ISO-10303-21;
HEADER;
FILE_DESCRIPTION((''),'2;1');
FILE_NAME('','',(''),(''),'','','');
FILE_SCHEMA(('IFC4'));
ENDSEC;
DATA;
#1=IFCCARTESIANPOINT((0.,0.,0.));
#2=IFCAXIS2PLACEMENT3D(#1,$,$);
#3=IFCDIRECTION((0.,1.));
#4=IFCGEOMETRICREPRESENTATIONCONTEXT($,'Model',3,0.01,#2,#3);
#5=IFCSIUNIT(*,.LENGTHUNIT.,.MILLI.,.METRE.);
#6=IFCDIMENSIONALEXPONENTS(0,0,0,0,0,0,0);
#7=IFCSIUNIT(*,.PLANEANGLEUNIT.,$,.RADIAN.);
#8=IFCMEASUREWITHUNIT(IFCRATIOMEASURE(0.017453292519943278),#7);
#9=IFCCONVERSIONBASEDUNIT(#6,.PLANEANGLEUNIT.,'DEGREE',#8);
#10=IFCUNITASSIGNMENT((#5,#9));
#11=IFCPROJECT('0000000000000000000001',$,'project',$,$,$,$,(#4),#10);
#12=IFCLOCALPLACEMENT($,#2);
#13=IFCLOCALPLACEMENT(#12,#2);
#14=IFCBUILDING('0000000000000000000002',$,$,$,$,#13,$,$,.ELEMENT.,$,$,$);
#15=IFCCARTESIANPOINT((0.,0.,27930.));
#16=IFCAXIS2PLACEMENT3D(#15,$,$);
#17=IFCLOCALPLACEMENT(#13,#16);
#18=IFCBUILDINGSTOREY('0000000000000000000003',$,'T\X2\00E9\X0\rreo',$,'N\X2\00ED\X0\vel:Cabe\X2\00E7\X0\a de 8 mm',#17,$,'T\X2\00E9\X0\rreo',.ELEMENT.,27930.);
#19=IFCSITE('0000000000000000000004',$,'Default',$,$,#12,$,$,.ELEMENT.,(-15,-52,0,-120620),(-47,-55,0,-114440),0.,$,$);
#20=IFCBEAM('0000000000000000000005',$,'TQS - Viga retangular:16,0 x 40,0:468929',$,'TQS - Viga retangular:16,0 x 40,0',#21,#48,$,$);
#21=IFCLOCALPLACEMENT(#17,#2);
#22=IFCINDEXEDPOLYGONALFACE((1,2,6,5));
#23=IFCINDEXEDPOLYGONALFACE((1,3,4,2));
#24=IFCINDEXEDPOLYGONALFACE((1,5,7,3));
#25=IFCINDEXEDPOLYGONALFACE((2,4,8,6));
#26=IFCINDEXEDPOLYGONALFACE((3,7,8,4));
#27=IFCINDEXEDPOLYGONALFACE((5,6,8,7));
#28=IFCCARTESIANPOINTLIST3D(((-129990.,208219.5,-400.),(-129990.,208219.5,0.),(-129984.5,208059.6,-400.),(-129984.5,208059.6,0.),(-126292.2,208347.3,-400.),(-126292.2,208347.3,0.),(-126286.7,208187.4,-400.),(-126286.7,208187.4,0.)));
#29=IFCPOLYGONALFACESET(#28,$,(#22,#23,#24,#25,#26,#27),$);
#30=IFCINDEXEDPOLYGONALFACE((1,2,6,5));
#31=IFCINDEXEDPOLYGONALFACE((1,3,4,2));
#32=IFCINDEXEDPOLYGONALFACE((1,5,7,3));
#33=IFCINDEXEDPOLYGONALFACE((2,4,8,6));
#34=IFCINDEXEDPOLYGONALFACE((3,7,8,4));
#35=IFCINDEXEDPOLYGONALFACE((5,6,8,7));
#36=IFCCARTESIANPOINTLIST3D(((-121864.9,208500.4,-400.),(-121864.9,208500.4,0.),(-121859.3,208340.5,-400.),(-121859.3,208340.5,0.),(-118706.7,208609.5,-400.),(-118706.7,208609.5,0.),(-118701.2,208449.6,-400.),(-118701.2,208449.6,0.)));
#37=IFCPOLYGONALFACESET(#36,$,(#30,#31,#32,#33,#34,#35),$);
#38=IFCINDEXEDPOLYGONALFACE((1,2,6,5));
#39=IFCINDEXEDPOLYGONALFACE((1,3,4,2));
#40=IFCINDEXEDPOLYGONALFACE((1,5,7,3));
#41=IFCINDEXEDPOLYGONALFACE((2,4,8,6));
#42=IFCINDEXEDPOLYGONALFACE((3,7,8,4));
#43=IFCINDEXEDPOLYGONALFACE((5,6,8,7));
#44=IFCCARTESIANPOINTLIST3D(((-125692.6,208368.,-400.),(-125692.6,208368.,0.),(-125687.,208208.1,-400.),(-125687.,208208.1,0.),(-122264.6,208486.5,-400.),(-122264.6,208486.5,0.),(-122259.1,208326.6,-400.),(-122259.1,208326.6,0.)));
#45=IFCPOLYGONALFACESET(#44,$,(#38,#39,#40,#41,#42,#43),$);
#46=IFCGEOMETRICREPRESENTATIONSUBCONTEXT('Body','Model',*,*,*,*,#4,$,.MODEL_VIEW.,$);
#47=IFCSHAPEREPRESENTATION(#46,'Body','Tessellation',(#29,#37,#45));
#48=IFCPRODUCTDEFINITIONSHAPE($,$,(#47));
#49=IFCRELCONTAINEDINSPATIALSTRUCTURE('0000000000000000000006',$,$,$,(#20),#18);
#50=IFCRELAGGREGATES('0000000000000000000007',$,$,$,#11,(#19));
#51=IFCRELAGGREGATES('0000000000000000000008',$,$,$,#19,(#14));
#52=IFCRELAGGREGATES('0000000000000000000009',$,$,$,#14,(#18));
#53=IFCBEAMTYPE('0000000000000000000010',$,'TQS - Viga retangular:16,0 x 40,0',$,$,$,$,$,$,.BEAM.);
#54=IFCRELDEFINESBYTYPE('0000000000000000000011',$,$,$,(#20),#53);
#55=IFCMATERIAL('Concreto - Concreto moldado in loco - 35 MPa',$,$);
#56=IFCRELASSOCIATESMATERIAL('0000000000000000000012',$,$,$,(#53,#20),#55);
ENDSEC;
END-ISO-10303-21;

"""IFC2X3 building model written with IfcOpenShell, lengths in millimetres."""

from ifc_helpers import new_model, entity, si_unit, converted_unit, direction, frame, frame_2d, origin, place, context, subcontext, project, spatial, rectangle, extrude, source, transform, mapped, material, type_object, type_shapes, element, save


model = new_model("IFC2X3")

# Units and contexts
model_context = context("Model", 3, precision=0.01, world=origin(), true_north=direction((0.0, 1.0)))
body_context = subcontext(model_context, "Body", "Model", "MODEL_VIEW")
ifc_project = project(units=[si_unit("LENGTHUNIT", "METRE", prefix="MILLI"), converted_unit("PLANEANGLEUNIT", "DEGREE", entity("IfcRatioMeasure", 0.017453292519943278), si_unit("PLANEANGLEUNIT", "RADIAN"), dimensions=[0, 0, 0, 0, 0, 0, 0])], contexts=[model_context])

# Site, building, storey
site_placement = place(None, origin())
site = spatial("IfcSite", under=ifc_project, at=site_placement, Name="Default", CompositionType="ELEMENT", RefLatitude=(-15, -52, 0, -120620), RefLongitude=(-47, -55, 0, -114440), RefElevation=0.0)
building_placement = place(site_placement, origin())
building = spatial("IfcBuilding", under=site, at=building_placement, CompositionType="ELEMENT")
storey_placement = place(building_placement, frame((0.0, 0.0, 27930.0)))
storey = spatial("IfcBuildingStorey", under=building, at=storey_placement, Name="Térreo", ObjectType="Nível:Cabeça de 8 mm", LongName="Térreo", CompositionType="ELEMENT", Elevation=27930.0)

# Shared definitions
ifc_material = material(Name="Concreto - Concreto moldado in loco - 35 MPa")

# Beam
beam_type_1 = type_object("IfcBeamType", Name="TQS - Viga retangular:16,0 x 40,0", PredefinedType="BEAM", material=ifc_material)
shared_shape_1 = source(origin(), body_context, "Body", "SweptSolid", [
    extrude(rectangle(XDim=400.0, YDim=160.0, at=frame_2d((0.0, 0.0), x_axis=(1.0, 0.0))), frame((-126289.4, 208267.4, 27730.0), z_axis=(-0.999403, -0.034551, 0.0), x_axis=(0.0, 0.0, -1.0)), (0.0, 0.0, 1.0), 3700.0),
    extrude(rectangle(XDim=400.0, YDim=160.0, at=frame_2d((0.0, 0.0), x_axis=(1.0, 0.0))), frame((-118704.0, 208529.6, 27730.0), z_axis=(-0.999403, -0.034551, 0.0), x_axis=(0.0, 0.0, -1.0)), (0.0, 0.0, 1.0), 3160.0),
    extrude(rectangle(XDim=400.0, YDim=160.0, at=frame_2d((0.0, 0.0), x_axis=(1.0, 0.0))), frame((-122261.9, 208406.6, 27730.0), z_axis=(-0.999403, -0.034551, 0.0), x_axis=(0.0, 0.0, -1.0)), (0.0, 0.0, 1.0), 3430.0),
])
type_shapes(beam_type_1, [shared_shape_1])
beam_1_placement = place(storey_placement, frame((0.0, 0.0, -27930.0)))
element("IfcBeam", 1, at=beam_1_placement, inside=storey, type_object=beam_type_1, material=ifc_material, Name="TQS - Viga retangular:16,0 x 40,0:468929", ObjectType="TQS - Viga retangular:16,0 x 40,0", context=body_context, shape_type="MappedRepresentation", body=[
    mapped(shared_shape_1, transform((0.0, 0.0, 0.0), scale=1.0)),
])

save(model, "model.ifc")
